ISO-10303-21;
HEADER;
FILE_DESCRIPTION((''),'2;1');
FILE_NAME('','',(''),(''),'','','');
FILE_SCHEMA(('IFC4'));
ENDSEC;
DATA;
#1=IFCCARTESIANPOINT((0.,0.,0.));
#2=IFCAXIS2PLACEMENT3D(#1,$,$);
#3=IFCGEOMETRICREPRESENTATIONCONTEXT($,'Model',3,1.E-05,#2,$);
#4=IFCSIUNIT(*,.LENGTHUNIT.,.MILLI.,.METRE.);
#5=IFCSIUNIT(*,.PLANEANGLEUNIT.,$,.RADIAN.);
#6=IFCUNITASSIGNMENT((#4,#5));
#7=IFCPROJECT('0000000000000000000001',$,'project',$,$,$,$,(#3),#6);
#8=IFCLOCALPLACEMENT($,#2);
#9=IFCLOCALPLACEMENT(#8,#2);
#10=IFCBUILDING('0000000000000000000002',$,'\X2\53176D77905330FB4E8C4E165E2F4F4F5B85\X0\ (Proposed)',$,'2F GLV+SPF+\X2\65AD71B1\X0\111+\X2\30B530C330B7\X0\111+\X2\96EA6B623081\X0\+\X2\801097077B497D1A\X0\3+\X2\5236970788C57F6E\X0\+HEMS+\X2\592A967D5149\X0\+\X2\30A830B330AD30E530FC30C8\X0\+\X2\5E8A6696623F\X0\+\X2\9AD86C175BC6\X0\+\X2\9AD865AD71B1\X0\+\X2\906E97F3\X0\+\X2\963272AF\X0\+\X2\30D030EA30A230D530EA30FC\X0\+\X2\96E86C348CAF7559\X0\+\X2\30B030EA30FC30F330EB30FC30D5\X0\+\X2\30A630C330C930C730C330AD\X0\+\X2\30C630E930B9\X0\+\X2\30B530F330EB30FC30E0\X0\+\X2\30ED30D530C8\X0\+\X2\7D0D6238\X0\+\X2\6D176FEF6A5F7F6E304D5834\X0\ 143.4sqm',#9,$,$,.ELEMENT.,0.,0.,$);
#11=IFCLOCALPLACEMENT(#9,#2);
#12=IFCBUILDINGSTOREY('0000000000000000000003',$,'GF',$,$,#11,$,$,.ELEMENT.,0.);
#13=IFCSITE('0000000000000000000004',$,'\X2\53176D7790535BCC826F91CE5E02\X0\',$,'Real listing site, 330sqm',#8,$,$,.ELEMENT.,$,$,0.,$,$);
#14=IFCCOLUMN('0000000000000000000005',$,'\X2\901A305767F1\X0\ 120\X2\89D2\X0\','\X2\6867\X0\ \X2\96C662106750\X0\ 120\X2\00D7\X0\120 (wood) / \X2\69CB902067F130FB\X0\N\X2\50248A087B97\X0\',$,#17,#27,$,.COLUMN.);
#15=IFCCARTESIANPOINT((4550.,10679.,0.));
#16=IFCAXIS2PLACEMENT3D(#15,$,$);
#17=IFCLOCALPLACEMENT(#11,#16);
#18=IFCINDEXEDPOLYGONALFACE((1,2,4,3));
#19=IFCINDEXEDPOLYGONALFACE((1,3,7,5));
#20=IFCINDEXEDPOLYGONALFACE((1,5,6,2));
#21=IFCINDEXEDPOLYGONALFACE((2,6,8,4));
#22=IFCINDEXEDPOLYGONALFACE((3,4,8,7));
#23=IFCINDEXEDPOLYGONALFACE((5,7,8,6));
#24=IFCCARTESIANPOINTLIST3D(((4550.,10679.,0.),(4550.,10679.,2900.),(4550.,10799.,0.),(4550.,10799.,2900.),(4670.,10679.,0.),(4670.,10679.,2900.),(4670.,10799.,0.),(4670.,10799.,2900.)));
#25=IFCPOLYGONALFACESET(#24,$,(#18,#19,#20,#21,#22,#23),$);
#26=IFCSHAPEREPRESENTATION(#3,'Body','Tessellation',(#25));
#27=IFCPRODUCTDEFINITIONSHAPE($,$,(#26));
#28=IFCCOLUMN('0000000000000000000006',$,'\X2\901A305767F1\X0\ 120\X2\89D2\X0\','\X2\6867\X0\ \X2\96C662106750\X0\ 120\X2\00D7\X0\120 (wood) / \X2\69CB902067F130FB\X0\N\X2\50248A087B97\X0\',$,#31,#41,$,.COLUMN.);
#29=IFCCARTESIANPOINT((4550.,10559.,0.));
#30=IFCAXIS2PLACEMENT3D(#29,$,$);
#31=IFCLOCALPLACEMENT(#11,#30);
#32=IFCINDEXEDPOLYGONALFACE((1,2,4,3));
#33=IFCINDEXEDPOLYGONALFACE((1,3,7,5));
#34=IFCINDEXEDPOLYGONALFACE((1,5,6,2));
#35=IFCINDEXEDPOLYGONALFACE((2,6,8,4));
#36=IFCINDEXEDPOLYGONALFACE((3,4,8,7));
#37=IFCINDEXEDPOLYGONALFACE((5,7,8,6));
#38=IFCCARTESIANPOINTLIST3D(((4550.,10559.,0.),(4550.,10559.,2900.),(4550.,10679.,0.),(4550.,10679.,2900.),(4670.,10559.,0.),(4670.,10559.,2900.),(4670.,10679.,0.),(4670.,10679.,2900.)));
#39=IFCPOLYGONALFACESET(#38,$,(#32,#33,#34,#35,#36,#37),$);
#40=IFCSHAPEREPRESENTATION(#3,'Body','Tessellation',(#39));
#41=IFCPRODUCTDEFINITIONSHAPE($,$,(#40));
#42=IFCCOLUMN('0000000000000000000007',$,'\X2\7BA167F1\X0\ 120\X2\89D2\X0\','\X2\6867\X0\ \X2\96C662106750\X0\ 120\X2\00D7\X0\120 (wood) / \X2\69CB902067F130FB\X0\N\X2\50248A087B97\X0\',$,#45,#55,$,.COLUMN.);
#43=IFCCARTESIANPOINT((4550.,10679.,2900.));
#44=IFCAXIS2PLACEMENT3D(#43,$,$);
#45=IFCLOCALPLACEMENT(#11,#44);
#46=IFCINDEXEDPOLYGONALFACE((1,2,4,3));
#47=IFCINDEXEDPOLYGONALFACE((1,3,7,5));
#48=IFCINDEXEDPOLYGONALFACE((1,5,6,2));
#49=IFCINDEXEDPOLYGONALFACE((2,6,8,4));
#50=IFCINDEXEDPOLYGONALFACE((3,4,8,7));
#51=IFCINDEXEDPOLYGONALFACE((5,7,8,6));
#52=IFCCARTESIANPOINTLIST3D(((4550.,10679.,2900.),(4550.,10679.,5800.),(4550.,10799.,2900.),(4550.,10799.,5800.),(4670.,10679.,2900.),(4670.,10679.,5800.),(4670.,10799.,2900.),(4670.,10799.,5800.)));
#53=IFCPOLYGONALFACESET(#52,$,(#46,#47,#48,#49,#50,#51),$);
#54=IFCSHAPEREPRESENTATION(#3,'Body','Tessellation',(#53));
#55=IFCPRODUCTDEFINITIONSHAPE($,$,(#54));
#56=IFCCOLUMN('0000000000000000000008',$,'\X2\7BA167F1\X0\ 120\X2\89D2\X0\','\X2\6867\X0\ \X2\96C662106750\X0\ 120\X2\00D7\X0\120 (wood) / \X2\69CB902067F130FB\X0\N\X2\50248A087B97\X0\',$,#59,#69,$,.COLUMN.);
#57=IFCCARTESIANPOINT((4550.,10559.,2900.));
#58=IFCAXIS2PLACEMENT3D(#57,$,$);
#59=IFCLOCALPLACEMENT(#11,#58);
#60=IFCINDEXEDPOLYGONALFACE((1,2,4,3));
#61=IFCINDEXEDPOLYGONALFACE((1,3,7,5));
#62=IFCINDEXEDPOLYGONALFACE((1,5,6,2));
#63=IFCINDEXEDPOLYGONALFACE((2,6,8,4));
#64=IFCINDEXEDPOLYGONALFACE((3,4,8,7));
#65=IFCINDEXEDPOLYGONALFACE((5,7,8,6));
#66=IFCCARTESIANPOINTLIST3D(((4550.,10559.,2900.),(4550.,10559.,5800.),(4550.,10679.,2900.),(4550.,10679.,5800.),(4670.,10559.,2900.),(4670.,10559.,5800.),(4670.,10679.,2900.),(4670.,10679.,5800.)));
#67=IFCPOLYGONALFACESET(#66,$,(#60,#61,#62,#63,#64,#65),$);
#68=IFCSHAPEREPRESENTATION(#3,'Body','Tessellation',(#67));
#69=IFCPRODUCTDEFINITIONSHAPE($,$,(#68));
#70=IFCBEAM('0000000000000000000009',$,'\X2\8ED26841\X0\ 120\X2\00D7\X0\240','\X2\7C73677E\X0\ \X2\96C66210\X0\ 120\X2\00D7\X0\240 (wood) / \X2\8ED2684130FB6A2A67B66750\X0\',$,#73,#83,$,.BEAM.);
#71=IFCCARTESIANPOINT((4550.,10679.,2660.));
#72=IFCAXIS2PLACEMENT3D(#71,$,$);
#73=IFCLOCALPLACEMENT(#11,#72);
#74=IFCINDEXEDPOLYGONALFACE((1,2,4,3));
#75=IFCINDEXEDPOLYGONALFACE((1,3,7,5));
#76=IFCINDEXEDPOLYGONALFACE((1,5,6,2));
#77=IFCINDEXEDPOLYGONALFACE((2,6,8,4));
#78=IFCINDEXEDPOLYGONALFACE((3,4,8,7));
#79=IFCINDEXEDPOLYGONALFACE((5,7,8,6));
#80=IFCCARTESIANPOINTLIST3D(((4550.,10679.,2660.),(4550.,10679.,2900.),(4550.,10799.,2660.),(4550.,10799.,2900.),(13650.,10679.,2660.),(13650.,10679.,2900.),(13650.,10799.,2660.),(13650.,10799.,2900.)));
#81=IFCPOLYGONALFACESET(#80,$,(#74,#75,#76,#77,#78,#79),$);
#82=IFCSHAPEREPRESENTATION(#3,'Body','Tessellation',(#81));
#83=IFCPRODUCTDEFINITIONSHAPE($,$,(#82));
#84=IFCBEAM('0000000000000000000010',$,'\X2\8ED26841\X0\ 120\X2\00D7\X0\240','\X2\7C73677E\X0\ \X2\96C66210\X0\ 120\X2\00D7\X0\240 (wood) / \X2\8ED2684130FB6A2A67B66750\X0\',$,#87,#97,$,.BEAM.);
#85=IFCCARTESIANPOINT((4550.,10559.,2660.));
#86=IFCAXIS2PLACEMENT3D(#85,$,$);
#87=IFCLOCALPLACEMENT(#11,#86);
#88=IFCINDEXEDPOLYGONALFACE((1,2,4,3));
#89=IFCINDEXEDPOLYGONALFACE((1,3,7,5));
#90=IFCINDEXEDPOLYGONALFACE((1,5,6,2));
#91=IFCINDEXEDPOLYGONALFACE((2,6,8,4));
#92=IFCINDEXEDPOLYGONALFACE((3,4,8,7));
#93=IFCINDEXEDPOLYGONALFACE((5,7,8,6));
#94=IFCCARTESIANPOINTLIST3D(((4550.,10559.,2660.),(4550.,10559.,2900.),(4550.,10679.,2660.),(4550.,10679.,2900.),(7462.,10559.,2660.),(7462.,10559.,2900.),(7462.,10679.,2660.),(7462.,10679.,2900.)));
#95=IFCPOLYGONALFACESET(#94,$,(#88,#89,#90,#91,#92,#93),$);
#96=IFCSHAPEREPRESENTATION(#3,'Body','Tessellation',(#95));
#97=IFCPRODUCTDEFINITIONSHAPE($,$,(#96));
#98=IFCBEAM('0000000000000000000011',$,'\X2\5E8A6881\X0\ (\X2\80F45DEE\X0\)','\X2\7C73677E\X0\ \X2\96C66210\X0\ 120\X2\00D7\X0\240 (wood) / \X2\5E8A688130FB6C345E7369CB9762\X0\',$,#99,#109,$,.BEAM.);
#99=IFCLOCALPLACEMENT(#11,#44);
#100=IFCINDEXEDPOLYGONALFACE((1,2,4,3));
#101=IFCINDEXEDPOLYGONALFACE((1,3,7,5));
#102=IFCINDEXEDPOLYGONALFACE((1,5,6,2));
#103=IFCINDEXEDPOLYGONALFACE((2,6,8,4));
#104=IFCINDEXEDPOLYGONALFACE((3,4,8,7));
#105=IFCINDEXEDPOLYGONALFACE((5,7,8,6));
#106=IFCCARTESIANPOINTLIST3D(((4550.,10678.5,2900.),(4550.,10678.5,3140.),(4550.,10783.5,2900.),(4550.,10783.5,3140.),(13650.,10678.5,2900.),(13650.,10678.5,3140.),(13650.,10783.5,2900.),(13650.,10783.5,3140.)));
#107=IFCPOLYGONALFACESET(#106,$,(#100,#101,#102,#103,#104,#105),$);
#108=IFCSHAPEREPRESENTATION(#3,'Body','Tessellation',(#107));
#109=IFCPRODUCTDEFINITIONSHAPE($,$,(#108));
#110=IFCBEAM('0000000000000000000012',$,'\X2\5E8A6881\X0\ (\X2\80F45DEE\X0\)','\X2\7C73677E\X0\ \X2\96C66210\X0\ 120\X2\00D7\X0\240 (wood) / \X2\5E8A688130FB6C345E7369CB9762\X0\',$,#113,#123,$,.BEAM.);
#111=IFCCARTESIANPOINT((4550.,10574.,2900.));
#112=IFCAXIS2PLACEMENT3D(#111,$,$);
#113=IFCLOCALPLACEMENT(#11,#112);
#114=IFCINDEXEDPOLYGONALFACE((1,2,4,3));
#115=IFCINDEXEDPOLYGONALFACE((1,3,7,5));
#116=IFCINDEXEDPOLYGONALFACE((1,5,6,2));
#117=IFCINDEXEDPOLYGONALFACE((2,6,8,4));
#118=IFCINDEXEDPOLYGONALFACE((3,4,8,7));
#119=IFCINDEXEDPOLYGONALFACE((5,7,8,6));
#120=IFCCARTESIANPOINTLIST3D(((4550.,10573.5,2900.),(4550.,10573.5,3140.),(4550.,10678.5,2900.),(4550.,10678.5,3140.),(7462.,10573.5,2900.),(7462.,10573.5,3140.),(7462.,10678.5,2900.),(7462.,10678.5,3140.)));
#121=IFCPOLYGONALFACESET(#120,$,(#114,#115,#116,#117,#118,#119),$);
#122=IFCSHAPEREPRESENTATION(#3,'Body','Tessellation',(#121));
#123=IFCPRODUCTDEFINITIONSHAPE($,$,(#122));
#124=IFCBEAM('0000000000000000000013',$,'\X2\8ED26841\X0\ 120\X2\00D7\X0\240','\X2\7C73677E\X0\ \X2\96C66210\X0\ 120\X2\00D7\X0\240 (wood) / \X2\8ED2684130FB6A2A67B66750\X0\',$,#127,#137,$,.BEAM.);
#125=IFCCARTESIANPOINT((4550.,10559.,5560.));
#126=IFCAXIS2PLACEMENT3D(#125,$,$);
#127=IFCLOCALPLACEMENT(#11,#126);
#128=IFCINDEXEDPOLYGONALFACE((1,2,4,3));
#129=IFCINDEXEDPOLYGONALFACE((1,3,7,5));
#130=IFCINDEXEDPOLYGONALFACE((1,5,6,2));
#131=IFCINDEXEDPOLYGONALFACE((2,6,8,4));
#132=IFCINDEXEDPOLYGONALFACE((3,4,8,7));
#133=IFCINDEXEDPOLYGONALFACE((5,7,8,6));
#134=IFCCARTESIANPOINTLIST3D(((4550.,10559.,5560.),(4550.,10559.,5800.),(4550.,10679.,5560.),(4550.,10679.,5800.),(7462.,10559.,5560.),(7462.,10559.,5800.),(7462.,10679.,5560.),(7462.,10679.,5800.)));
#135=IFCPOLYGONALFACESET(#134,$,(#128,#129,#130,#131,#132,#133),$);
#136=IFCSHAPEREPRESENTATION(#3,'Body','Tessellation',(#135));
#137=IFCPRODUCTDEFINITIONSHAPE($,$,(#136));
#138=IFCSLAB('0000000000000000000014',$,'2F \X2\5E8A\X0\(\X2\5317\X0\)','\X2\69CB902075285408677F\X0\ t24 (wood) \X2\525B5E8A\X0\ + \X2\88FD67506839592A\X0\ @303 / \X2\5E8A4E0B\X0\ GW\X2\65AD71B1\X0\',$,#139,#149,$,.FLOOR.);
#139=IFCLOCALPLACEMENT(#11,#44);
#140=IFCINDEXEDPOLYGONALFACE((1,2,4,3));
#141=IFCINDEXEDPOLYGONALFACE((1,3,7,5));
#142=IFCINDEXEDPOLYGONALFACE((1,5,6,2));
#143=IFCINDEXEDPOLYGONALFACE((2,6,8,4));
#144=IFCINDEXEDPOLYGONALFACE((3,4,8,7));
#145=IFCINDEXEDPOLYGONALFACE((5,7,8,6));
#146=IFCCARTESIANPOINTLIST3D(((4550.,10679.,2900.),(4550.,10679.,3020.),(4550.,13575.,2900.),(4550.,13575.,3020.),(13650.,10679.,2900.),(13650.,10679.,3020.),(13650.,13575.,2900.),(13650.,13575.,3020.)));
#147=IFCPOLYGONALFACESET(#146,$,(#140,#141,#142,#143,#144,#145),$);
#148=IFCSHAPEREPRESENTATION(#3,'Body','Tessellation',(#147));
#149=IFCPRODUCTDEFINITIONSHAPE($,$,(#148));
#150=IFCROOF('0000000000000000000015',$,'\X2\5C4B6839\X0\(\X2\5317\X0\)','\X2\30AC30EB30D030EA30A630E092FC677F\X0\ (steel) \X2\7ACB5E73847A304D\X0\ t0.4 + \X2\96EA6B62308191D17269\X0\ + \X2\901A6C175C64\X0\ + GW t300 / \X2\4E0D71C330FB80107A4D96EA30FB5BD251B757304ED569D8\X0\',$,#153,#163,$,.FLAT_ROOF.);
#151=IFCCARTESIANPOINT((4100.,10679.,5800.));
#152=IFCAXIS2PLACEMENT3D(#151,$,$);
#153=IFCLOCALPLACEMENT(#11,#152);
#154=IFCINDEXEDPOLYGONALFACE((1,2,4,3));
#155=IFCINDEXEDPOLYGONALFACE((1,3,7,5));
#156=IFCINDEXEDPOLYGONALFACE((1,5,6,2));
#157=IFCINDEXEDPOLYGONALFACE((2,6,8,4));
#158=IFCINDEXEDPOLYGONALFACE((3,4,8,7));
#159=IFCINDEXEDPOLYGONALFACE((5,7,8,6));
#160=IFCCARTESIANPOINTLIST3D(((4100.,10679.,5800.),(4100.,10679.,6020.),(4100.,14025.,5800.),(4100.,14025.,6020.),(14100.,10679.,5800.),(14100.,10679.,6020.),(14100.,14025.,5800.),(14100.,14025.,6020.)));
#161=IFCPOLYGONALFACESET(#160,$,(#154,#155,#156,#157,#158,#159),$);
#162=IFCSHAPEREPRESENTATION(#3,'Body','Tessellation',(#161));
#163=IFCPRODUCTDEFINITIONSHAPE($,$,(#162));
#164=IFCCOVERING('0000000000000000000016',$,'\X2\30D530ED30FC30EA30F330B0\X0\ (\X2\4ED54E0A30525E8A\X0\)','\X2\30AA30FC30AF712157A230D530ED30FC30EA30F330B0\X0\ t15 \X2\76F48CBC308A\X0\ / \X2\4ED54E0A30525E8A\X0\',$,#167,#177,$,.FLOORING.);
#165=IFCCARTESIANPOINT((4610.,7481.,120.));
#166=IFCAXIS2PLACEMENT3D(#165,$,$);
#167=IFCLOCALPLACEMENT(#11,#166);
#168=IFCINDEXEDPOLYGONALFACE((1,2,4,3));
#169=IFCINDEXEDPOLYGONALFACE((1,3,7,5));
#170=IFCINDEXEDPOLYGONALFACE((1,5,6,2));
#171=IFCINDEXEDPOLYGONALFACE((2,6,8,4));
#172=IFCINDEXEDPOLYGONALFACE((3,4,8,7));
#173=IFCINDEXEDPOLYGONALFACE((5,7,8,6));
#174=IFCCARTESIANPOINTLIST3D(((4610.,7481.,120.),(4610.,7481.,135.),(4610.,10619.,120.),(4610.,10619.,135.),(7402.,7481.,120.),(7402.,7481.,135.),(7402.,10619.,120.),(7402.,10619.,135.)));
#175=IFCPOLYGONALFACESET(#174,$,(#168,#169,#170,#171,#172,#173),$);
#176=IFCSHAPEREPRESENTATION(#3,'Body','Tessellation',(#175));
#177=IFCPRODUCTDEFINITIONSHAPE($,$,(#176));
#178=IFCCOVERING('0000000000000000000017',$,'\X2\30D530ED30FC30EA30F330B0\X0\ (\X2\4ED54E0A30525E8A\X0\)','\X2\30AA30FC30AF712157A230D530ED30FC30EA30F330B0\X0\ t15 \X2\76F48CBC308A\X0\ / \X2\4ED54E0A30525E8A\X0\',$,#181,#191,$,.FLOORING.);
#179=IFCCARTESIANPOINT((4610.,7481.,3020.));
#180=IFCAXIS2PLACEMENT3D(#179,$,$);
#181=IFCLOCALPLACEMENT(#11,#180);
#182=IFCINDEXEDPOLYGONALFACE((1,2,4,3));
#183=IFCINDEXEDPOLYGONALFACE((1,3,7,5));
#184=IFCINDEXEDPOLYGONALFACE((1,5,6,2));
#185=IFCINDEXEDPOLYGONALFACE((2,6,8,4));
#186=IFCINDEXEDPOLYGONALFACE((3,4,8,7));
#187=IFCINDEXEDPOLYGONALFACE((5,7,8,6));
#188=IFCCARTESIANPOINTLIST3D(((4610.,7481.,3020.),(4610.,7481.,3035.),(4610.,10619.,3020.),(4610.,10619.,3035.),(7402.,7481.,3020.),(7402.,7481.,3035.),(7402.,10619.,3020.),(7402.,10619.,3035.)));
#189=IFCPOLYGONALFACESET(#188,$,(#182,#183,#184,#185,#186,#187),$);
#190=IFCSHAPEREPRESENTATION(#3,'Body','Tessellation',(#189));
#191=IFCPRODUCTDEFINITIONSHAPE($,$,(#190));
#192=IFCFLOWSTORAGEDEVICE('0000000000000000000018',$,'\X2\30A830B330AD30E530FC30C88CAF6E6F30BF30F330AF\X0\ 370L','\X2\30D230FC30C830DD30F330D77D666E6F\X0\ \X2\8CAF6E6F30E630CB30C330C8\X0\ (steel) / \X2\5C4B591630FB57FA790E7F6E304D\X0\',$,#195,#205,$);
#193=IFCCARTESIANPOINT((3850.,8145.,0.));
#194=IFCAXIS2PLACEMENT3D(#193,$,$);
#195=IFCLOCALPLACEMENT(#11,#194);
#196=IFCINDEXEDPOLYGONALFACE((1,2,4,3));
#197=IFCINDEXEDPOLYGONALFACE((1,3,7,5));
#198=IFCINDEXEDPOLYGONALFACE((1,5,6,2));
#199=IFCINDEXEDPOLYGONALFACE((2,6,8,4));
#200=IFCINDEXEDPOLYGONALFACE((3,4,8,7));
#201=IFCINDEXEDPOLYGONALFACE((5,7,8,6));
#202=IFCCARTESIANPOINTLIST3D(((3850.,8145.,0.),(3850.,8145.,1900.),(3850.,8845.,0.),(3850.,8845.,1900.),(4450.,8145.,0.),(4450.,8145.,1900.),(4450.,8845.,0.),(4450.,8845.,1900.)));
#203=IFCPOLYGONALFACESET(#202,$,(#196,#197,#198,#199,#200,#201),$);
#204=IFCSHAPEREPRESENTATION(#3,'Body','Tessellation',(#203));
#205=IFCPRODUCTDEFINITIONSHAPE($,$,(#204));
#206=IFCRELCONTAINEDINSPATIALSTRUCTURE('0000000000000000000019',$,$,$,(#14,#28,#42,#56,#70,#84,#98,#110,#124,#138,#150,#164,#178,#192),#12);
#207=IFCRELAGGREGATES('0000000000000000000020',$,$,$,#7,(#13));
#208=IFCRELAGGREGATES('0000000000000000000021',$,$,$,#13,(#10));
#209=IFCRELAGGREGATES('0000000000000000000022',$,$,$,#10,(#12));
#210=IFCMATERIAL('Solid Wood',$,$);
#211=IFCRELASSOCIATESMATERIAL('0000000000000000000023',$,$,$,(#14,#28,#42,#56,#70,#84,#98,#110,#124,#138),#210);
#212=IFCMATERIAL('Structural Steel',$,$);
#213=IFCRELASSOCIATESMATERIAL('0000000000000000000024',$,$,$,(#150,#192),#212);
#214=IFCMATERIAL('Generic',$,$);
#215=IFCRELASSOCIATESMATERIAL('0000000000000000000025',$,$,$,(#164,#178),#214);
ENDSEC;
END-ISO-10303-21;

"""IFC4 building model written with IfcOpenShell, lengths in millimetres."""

from ifc_helpers import new_model, si_unit, frame, frame_2d, origin, place, context, project, spatial, rectangle, extrude, material, element, save


model = new_model("IFC4")

# Units and contexts
model_context = context("Model", 3, precision=1e-05, world=origin())
ifc_project = project(units=[si_unit("LENGTHUNIT", "METRE", prefix="MILLI"), si_unit("PLANEANGLEUNIT", "RADIAN")], contexts=[model_context])

# Site, building, storey
site_placement = place(None, origin())
site = spatial("IfcSite", under=ifc_project, at=site_placement, Name="北海道富良野市", ObjectType="Real listing site, 330sqm", CompositionType="ELEMENT", RefElevation=0.0)
building_placement = place(site_placement, origin())
building = spatial("IfcBuilding", under=site, at=building_placement, Name="北海道・二世帯住宅 (Proposed)", ObjectType="2F GLV+SPF+断熱111+サッシ111+雪止め+耐震等級3+制震装置+HEMS+太陽光+エコキュート+床暖房+高気密+高断熱+遮音+防犯+バリアフリー+雨水貯留+グリーンルーフ+ウッドデッキ+テラス+サンルーム+ロフト+納戸+洗濯機置き場 143.4sqm", CompositionType="ELEMENT", ElevationOfRefHeight=0.0, ElevationOfTerrain=0.0)
storey_placement = place(building_placement, origin())
storey = spatial("IfcBuildingStorey", under=building, at=storey_placement, Name="GF", CompositionType="ELEMENT", Elevation=0.0)

# Columns
ifc_material_1 = material(Name="Solid Wood")
column_1_placement = place(storey_placement, frame((4550.0, 10679.0, 0.0)))
element("IfcColumn", 1, at=column_1_placement, inside=storey, material=ifc_material_1, Name="通し柱 120角", Description="桧 集成材 120×120 (wood) / 構造柱・N値計算", PredefinedType="COLUMN", context=model_context, shape_type="SweptSolid", body=[
    extrude(rectangle(XDim=120.0, YDim=120.0, at=frame_2d((60.0, 60.0))), frame((4550.0, 10679.0, 0.0)), (0.0, 0.0, 1.0), 2900.0),
])
column_2_placement = place(storey_placement, frame((4550.0, 10559.0, 0.0)))
element("IfcColumn", 2, at=column_2_placement, inside=storey, material=ifc_material_1, Name="通し柱 120角", Description="桧 集成材 120×120 (wood) / 構造柱・N値計算", PredefinedType="COLUMN", context=model_context, shape_type="SweptSolid", body=[
    extrude(rectangle(XDim=120.0, YDim=120.0, at=frame_2d((60.0, 60.0))), frame((4550.0, 10559.0, 0.0)), (0.0, 0.0, 1.0), 2900.0),
])
column_3_placement = place(storey_placement, frame((4550.0, 10679.0, 2900.0)))
element("IfcColumn", 3, at=column_3_placement, inside=storey, material=ifc_material_1, Name="管柱 120角", Description="桧 集成材 120×120 (wood) / 構造柱・N値計算", PredefinedType="COLUMN", context=model_context, shape_type="SweptSolid", body=[
    extrude(rectangle(XDim=120.0, YDim=120.0, at=frame_2d((60.0, 60.0))), frame((4550.0, 10679.0, 2900.0)), (0.0, 0.0, 1.0), 2900.0),
])
column_4_placement = place(storey_placement, frame((4550.0, 10559.0, 2900.0)))
element("IfcColumn", 4, at=column_4_placement, inside=storey, material=ifc_material_1, Name="管柱 120角", Description="桧 集成材 120×120 (wood) / 構造柱・N値計算", PredefinedType="COLUMN", context=model_context, shape_type="SweptSolid", body=[
    extrude(rectangle(XDim=120.0, YDim=120.0, at=frame_2d((60.0, 60.0))), frame((4550.0, 10559.0, 2900.0)), (0.0, 0.0, 1.0), 2900.0),
])

# Beams
beam_1_placement = place(storey_placement, frame((4550.0, 10679.0, 2660.0)))
element("IfcBeam", 5, at=beam_1_placement, inside=storey, material=ifc_material_1, Name="軒桁 120×240", Description="米松 集成 120×240 (wood) / 軒桁・横架材", PredefinedType="BEAM", context=model_context, shape_type="SweptSolid", body=[
    extrude(rectangle(XDim=9100.0, YDim=120.0, at=frame_2d((4550.0, 60.0))), frame((4550.0, 10679.0, 2660.0)), (0.0, 0.0, 1.0), 240.0),
])
beam_2_placement = place(storey_placement, frame((4550.0, 10559.0, 2660.0)))
element("IfcBeam", 6, at=beam_2_placement, inside=storey, material=ifc_material_1, Name="軒桁 120×240", Description="米松 集成 120×240 (wood) / 軒桁・横架材", PredefinedType="BEAM", context=model_context, shape_type="SweptSolid", body=[
    extrude(rectangle(XDim=2912.0, YDim=120.0, at=frame_2d((1456.0, 60.0))), frame((4550.0, 10559.0, 2660.0)), (0.0, 0.0, 1.0), 240.0),
])
beam_3_placement = place(storey_placement, frame((4550.0, 10679.0, 2900.0)))
element("IfcBeam", 7, at=beam_3_placement, inside=storey, material=ifc_material_1, Name="床梁 (胴差)", Description="米松 集成 120×240 (wood) / 床梁・水平構面", PredefinedType="BEAM", context=model_context, shape_type="SweptSolid", body=[
    extrude(rectangle(XDim=9100.0, YDim=105.0, at=frame_2d((4550.0, 52.0))), frame((4550.0, 10679.0, 2900.0)), (0.0, 0.0, 1.0), 240.0),
])
beam_4_placement = place(storey_placement, frame((4550.0, 10574.0, 2900.0)))
element("IfcBeam", 8, at=beam_4_placement, inside=storey, material=ifc_material_1, Name="床梁 (胴差)", Description="米松 集成 120×240 (wood) / 床梁・水平構面", PredefinedType="BEAM", context=model_context, shape_type="SweptSolid", body=[
    extrude(rectangle(XDim=2912.0, YDim=105.0, at=frame_2d((1456.0, 52.0))), frame((4550.0, 10574.0, 2900.0)), (0.0, 0.0, 1.0), 240.0),
])
beam_5_placement = place(storey_placement, frame((4550.0, 10559.0, 5560.0)))
element("IfcBeam", 9, at=beam_5_placement, inside=storey, material=ifc_material_1, Name="軒桁 120×240", Description="米松 集成 120×240 (wood) / 軒桁・横架材", PredefinedType="BEAM", context=model_context, shape_type="SweptSolid", body=[
    extrude(rectangle(XDim=2912.0, YDim=120.0, at=frame_2d((1456.0, 60.0))), frame((4550.0, 10559.0, 5560.0)), (0.0, 0.0, 1.0), 240.0),
])

# Slab
slab_1_placement = place(storey_placement, frame((4550.0, 10679.0, 2900.0)))
element("IfcSlab", 10, at=slab_1_placement, inside=storey, material=ifc_material_1, Name="2F 床(北)", Description="構造用合板 t24 (wood) 剛床 + 製材根太 @303 / 床下 GW断熱", PredefinedType="FLOOR", context=model_context, shape_type="SweptSolid", body=[
    extrude(rectangle(XDim=9100.0, YDim=2896.0, at=frame_2d((4550.0, 1448.0))), frame((4550.0, 10679.0, 2900.0)), (0.0, 0.0, 1.0), 120.0),
])

# Roof
ifc_material_2 = material(Name="Structural Steel")
for number, where, name in (
    (11, (4100.0, 10679.0, 5800.0), "屋根(北)"),
):
    element("IfcRoof", number, at=place(storey_placement, frame(where)), inside=storey, material=ifc_material_2, Name=name, Description="ガルバリウム鋼板 (steel) 立平葺き t0.4 + 雪止め金物 + 通気層 + GW t300 / 不燃・耐積雪・寒冷地仕様", PredefinedType="FLAT_ROOF", context=model_context, shape_type="SweptSolid", body=[
        extrude(rectangle(XDim=10000.0, YDim=3346.0, at=frame_2d((5000.0, 1673.0))), frame((4100.0, 10679.0, 5800.0)), (0.0, 0.0, 1.0), 220.0),
    ])

# Coverings
ifc_material_3 = material(Name="Generic")
covering_1_placement = place(storey_placement, frame((4610.0, 7481.0, 120.0)))
element("IfcCovering", 12, at=covering_1_placement, inside=storey, material=ifc_material_3, Name="フローリング (仕上げ床)", Description="オーク無垢フローリング t15 直貼り / 仕上げ床", PredefinedType="FLOORING", context=model_context, shape_type="SweptSolid", body=[
    extrude(rectangle(XDim=2792.0, YDim=3138.0, at=frame_2d((1396.0, 1569.0))), frame((4610.0, 7481.0, 120.0)), (0.0, 0.0, 1.0), 15.0),
])
covering_2_placement = place(storey_placement, frame((4610.0, 7481.0, 3020.0)))
element("IfcCovering", 13, at=covering_2_placement, inside=storey, material=ifc_material_3, Name="フローリング (仕上げ床)", Description="オーク無垢フローリング t15 直貼り / 仕上げ床", PredefinedType="FLOORING", context=model_context, shape_type="SweptSolid", body=[
    extrude(rectangle(XDim=2792.0, YDim=3138.0, at=frame_2d((1396.0, 1569.0))), frame((4610.0, 7481.0, 3020.0)), (0.0, 0.0, 1.0), 15.0),
])

# Flow storage device
flow_storage_device_placement = place(storey_placement, frame((3850.0, 8145.0, 0.0)))
element("IfcFlowStorageDevice", 14, at=flow_storage_device_placement, inside=storey, material=ifc_material_2, Name="エコキュート貯湯タンク 370L", Description="ヒートポンプ給湯 貯湯ユニット (steel) / 屋外・基礎置き", context=model_context, shape_type="SweptSolid", body=[
    extrude(rectangle(XDim=600.0, YDim=700.0, at=frame_2d((300.0, 350.0))), frame((3850.0, 8145.0, 0.0)), (0.0, 0.0, 1.0), 1900.0),
])

save(model, "model.ifc")
